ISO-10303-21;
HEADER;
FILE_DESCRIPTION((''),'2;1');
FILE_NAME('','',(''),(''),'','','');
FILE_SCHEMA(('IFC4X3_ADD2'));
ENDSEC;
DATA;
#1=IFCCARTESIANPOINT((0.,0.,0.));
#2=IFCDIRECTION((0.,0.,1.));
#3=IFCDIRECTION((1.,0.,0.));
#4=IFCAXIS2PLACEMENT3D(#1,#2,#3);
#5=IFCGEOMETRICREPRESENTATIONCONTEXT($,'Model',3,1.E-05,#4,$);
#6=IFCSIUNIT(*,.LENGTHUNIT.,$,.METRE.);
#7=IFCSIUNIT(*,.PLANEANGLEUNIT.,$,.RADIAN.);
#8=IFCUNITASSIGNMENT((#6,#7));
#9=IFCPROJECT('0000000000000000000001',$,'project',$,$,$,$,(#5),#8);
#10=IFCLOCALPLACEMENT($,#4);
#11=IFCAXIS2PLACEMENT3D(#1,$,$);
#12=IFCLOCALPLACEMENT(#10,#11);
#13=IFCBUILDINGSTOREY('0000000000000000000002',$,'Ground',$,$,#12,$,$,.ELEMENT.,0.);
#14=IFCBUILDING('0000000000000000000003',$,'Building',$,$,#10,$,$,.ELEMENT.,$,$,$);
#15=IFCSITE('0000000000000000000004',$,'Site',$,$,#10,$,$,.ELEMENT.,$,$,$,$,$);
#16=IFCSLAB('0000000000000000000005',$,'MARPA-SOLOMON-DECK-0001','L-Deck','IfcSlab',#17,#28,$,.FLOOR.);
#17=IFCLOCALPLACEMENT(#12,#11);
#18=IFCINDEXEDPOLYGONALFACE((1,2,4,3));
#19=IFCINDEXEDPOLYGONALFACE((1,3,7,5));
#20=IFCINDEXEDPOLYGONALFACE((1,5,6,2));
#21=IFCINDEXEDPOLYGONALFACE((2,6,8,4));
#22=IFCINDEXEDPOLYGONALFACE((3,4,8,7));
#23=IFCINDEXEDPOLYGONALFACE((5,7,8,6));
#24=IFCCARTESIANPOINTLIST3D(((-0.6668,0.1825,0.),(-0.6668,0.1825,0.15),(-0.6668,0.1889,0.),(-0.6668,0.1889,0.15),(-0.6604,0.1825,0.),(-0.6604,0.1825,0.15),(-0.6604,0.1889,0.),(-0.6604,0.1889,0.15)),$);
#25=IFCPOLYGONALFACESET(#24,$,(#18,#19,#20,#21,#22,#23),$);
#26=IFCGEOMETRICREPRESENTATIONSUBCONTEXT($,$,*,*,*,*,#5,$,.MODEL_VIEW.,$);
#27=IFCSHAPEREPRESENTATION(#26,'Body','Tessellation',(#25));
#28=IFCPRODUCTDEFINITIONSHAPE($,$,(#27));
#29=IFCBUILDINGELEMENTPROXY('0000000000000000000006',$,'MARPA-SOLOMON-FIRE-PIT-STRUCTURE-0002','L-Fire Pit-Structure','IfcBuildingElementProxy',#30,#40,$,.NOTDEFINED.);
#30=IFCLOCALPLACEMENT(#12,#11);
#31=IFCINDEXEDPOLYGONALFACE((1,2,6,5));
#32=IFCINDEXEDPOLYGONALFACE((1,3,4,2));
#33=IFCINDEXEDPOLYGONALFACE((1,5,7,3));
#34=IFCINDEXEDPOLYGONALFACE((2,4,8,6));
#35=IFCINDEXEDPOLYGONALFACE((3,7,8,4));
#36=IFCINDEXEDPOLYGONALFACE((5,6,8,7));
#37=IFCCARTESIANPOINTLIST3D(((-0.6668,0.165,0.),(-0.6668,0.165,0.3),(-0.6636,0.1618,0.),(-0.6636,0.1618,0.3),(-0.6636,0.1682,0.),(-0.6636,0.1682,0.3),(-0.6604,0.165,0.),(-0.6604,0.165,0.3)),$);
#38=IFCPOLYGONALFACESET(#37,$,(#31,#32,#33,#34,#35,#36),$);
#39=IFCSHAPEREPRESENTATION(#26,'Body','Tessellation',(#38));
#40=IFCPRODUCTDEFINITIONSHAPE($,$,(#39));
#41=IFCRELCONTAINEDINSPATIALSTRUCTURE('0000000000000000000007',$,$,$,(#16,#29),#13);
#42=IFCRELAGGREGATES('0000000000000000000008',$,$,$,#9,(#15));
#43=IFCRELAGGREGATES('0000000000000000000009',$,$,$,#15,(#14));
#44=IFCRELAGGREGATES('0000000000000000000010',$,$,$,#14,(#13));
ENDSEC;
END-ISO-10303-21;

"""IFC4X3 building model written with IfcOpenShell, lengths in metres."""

from ifc_helpers import new_model, si_unit, frame, origin, origin_with_axes, place, context, subcontext, project, spatial, polyline, outline, extrude, element, save


model = new_model("IFC4X3")

# Units and contexts
model_context = context("Model", 3, precision=1e-05, world=origin_with_axes())
sub_context = subcontext(model_context, None, None, "MODEL_VIEW")
ifc_project = project(units=[si_unit("LENGTHUNIT", "METRE"), si_unit("PLANEANGLEUNIT", "RADIAN")], contexts=[model_context])

# Site, building, storey
placement = place(None, origin_with_axes())
site = spatial("IfcSite", under=ifc_project, at=placement, Name="Site", CompositionType="ELEMENT")
building = spatial("IfcBuilding", under=site, at=placement, Name="Building", CompositionType="ELEMENT")
storey_placement = place(placement, origin())
storey = spatial("IfcBuildingStorey", under=building, at=storey_placement, Name="Ground", CompositionType="ELEMENT", Elevation=0.0)

# Slab
for number, where, name in (
    (1, (-0.6668, 0.1825, 0.0), "MARPA-SOLOMON-DECK-0001"),
):
    element("IfcSlab", number, at=place(storey_placement, frame(where)), inside=storey, Name=name, Description="L-Deck", ObjectType="IfcSlab", PredefinedType="FLOOR", context=sub_context, shape_type="SweptSolid", body=[
        extrude(outline(polyline([(0.0, 0.0063), (0.0063, 0.0063), (0.0063, 0.0), (0.0, 0.0), (0.0, 0.0063)])), origin(), (0.0, 0.0, 1.0), 0.15),
    ])

# Building element proxy
for number, where, name in (
    (2, (-0.6668, 0.1618, 0.0), "MARPA-SOLOMON-FIRE-PIT-STRUCTURE-0002"),
):
    element("IfcBuildingElementProxy", number, at=place(placement, frame(where)), inside=storey, Name=name, Description="L-Fire Pit-Structure", ObjectType="IfcBuildingElementProxy", PredefinedType="NOTDEFINED", context=sub_context, shape_type="SweptSolid", body=[
        extrude(outline(polyline([(0.0, 0.0032), (0.0032, 0.0063), (0.0063, 0.0032), (0.0032, 0.0), (0.0, 0.0032)])), origin(), (0.0, 0.0, 1.0), 0.3),
    ])

save(model, "model.ifc")
